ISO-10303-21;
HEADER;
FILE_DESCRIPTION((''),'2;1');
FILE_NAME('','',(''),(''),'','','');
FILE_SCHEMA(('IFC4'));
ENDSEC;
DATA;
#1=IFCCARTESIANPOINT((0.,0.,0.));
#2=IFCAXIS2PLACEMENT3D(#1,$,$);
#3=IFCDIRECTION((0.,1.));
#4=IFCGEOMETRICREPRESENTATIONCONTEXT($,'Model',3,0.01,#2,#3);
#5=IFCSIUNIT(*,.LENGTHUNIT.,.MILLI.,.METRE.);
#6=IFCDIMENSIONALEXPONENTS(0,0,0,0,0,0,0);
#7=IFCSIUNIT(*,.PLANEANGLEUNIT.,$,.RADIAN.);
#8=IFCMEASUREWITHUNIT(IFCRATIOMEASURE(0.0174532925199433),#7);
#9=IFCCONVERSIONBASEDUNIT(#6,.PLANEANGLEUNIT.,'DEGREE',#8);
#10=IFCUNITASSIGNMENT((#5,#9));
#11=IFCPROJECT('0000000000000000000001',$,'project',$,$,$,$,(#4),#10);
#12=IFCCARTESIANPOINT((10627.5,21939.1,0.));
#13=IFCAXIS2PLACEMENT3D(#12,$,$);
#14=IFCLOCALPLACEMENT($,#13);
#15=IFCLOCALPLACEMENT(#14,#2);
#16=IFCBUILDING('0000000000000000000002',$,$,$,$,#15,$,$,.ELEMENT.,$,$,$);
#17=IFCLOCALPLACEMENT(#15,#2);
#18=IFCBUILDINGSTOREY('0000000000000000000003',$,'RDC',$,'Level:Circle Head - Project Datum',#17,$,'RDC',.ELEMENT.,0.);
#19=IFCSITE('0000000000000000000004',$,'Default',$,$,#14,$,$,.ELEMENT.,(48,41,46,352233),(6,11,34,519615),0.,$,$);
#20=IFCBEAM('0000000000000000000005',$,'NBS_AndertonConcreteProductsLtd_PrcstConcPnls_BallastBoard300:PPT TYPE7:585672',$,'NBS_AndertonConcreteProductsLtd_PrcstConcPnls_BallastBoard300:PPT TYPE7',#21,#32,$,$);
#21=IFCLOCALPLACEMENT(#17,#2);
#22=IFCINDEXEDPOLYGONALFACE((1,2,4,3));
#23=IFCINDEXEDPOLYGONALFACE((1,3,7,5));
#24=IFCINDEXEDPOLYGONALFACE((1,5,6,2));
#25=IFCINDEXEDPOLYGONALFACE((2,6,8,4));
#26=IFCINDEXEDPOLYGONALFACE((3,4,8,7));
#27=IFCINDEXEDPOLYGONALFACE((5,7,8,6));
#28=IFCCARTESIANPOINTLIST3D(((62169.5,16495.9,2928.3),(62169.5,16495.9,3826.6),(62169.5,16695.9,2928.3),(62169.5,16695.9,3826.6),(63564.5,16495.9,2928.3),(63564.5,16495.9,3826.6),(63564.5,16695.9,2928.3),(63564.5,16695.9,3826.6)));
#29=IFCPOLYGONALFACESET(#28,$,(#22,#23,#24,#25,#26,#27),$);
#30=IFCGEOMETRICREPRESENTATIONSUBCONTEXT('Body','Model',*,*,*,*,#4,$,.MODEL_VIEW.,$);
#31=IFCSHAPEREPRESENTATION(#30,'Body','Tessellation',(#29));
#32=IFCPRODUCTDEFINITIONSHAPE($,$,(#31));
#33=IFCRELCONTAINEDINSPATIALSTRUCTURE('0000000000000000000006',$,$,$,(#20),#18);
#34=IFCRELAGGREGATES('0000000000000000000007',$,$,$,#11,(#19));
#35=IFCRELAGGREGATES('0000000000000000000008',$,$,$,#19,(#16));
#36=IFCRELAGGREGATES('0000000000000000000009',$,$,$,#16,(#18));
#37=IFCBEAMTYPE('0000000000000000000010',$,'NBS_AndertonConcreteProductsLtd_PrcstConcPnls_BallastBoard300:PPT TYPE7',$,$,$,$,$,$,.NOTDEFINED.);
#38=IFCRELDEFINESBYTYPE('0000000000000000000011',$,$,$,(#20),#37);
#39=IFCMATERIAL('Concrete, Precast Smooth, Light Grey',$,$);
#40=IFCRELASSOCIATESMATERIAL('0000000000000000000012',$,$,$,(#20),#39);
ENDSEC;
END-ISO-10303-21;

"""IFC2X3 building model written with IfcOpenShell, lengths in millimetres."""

from ifc_helpers import new_model, entity, si_unit, converted_unit, direction, frame, frame_2d, origin, place, context, subcontext, project, spatial, rectangle, extrude, material, type_object, element, save


model = new_model("IFC2X3")

# Units and contexts
model_context = context("Model", 3, precision=0.01, world=origin(), true_north=direction((0.0, 1.0)))
body_context = subcontext(model_context, "Body", "Model", "MODEL_VIEW")
ifc_project = project(units=[si_unit("LENGTHUNIT", "METRE", prefix="MILLI"), converted_unit("PLANEANGLEUNIT", "DEGREE", entity("IfcRatioMeasure", 0.0174532925199433), si_unit("PLANEANGLEUNIT", "RADIAN"), dimensions=[0, 0, 0, 0, 0, 0, 0])], contexts=[model_context])

# Site, building, storey
site_placement = place(None, frame((10627.5, 21939.1, 0.0)))
site = spatial("IfcSite", under=ifc_project, at=site_placement, Name="Default", CompositionType="ELEMENT", RefLatitude=(48, 41, 46, 352233), RefLongitude=(6, 11, 34, 519615), RefElevation=0.0)
building_placement = place(site_placement, origin())
building = spatial("IfcBuilding", under=site, at=building_placement, CompositionType="ELEMENT")
storey_placement = place(building_placement, origin())
storey = spatial("IfcBuildingStorey", under=building, at=storey_placement, Name="RDC", ObjectType="Level:Circle Head - Project Datum", LongName="RDC", CompositionType="ELEMENT", Elevation=0.0)

# Shared definitions
ifc_material = material(Name="Concrete, Precast Smooth, Light Grey")

# Beam
beam_type_1 = type_object("IfcBeamType", Name="NBS_AndertonConcreteProductsLtd_PrcstConcPnls_BallastBoard300:PPT TYPE7", PredefinedType="NOTDEFINED")
beam_1_placement = place(storey_placement, origin())
element("IfcBeam", 1, at=beam_1_placement, inside=storey, type_object=beam_type_1, material=ifc_material, Name="NBS_AndertonConcreteProductsLtd_PrcstConcPnls_BallastBoard300:PPT TYPE7:585672", ObjectType="NBS_AndertonConcreteProductsLtd_PrcstConcPnls_BallastBoard300:PPT TYPE7", context=body_context, shape_type="SweptSolid", body=[
    extrude(rectangle(XDim=898.3, YDim=200.0, at=frame_2d((0.0, 0.0), x_axis=(1.0, 0.0))), frame((62169.5, 16595.9, 3377.4), z_axis=(1.0, 0.0, 0.0), x_axis=(0.0, 0.0, -1.0)), (0.0, 0.0, 1.0), 1395.0),
])

save(model, "model.ifc")
